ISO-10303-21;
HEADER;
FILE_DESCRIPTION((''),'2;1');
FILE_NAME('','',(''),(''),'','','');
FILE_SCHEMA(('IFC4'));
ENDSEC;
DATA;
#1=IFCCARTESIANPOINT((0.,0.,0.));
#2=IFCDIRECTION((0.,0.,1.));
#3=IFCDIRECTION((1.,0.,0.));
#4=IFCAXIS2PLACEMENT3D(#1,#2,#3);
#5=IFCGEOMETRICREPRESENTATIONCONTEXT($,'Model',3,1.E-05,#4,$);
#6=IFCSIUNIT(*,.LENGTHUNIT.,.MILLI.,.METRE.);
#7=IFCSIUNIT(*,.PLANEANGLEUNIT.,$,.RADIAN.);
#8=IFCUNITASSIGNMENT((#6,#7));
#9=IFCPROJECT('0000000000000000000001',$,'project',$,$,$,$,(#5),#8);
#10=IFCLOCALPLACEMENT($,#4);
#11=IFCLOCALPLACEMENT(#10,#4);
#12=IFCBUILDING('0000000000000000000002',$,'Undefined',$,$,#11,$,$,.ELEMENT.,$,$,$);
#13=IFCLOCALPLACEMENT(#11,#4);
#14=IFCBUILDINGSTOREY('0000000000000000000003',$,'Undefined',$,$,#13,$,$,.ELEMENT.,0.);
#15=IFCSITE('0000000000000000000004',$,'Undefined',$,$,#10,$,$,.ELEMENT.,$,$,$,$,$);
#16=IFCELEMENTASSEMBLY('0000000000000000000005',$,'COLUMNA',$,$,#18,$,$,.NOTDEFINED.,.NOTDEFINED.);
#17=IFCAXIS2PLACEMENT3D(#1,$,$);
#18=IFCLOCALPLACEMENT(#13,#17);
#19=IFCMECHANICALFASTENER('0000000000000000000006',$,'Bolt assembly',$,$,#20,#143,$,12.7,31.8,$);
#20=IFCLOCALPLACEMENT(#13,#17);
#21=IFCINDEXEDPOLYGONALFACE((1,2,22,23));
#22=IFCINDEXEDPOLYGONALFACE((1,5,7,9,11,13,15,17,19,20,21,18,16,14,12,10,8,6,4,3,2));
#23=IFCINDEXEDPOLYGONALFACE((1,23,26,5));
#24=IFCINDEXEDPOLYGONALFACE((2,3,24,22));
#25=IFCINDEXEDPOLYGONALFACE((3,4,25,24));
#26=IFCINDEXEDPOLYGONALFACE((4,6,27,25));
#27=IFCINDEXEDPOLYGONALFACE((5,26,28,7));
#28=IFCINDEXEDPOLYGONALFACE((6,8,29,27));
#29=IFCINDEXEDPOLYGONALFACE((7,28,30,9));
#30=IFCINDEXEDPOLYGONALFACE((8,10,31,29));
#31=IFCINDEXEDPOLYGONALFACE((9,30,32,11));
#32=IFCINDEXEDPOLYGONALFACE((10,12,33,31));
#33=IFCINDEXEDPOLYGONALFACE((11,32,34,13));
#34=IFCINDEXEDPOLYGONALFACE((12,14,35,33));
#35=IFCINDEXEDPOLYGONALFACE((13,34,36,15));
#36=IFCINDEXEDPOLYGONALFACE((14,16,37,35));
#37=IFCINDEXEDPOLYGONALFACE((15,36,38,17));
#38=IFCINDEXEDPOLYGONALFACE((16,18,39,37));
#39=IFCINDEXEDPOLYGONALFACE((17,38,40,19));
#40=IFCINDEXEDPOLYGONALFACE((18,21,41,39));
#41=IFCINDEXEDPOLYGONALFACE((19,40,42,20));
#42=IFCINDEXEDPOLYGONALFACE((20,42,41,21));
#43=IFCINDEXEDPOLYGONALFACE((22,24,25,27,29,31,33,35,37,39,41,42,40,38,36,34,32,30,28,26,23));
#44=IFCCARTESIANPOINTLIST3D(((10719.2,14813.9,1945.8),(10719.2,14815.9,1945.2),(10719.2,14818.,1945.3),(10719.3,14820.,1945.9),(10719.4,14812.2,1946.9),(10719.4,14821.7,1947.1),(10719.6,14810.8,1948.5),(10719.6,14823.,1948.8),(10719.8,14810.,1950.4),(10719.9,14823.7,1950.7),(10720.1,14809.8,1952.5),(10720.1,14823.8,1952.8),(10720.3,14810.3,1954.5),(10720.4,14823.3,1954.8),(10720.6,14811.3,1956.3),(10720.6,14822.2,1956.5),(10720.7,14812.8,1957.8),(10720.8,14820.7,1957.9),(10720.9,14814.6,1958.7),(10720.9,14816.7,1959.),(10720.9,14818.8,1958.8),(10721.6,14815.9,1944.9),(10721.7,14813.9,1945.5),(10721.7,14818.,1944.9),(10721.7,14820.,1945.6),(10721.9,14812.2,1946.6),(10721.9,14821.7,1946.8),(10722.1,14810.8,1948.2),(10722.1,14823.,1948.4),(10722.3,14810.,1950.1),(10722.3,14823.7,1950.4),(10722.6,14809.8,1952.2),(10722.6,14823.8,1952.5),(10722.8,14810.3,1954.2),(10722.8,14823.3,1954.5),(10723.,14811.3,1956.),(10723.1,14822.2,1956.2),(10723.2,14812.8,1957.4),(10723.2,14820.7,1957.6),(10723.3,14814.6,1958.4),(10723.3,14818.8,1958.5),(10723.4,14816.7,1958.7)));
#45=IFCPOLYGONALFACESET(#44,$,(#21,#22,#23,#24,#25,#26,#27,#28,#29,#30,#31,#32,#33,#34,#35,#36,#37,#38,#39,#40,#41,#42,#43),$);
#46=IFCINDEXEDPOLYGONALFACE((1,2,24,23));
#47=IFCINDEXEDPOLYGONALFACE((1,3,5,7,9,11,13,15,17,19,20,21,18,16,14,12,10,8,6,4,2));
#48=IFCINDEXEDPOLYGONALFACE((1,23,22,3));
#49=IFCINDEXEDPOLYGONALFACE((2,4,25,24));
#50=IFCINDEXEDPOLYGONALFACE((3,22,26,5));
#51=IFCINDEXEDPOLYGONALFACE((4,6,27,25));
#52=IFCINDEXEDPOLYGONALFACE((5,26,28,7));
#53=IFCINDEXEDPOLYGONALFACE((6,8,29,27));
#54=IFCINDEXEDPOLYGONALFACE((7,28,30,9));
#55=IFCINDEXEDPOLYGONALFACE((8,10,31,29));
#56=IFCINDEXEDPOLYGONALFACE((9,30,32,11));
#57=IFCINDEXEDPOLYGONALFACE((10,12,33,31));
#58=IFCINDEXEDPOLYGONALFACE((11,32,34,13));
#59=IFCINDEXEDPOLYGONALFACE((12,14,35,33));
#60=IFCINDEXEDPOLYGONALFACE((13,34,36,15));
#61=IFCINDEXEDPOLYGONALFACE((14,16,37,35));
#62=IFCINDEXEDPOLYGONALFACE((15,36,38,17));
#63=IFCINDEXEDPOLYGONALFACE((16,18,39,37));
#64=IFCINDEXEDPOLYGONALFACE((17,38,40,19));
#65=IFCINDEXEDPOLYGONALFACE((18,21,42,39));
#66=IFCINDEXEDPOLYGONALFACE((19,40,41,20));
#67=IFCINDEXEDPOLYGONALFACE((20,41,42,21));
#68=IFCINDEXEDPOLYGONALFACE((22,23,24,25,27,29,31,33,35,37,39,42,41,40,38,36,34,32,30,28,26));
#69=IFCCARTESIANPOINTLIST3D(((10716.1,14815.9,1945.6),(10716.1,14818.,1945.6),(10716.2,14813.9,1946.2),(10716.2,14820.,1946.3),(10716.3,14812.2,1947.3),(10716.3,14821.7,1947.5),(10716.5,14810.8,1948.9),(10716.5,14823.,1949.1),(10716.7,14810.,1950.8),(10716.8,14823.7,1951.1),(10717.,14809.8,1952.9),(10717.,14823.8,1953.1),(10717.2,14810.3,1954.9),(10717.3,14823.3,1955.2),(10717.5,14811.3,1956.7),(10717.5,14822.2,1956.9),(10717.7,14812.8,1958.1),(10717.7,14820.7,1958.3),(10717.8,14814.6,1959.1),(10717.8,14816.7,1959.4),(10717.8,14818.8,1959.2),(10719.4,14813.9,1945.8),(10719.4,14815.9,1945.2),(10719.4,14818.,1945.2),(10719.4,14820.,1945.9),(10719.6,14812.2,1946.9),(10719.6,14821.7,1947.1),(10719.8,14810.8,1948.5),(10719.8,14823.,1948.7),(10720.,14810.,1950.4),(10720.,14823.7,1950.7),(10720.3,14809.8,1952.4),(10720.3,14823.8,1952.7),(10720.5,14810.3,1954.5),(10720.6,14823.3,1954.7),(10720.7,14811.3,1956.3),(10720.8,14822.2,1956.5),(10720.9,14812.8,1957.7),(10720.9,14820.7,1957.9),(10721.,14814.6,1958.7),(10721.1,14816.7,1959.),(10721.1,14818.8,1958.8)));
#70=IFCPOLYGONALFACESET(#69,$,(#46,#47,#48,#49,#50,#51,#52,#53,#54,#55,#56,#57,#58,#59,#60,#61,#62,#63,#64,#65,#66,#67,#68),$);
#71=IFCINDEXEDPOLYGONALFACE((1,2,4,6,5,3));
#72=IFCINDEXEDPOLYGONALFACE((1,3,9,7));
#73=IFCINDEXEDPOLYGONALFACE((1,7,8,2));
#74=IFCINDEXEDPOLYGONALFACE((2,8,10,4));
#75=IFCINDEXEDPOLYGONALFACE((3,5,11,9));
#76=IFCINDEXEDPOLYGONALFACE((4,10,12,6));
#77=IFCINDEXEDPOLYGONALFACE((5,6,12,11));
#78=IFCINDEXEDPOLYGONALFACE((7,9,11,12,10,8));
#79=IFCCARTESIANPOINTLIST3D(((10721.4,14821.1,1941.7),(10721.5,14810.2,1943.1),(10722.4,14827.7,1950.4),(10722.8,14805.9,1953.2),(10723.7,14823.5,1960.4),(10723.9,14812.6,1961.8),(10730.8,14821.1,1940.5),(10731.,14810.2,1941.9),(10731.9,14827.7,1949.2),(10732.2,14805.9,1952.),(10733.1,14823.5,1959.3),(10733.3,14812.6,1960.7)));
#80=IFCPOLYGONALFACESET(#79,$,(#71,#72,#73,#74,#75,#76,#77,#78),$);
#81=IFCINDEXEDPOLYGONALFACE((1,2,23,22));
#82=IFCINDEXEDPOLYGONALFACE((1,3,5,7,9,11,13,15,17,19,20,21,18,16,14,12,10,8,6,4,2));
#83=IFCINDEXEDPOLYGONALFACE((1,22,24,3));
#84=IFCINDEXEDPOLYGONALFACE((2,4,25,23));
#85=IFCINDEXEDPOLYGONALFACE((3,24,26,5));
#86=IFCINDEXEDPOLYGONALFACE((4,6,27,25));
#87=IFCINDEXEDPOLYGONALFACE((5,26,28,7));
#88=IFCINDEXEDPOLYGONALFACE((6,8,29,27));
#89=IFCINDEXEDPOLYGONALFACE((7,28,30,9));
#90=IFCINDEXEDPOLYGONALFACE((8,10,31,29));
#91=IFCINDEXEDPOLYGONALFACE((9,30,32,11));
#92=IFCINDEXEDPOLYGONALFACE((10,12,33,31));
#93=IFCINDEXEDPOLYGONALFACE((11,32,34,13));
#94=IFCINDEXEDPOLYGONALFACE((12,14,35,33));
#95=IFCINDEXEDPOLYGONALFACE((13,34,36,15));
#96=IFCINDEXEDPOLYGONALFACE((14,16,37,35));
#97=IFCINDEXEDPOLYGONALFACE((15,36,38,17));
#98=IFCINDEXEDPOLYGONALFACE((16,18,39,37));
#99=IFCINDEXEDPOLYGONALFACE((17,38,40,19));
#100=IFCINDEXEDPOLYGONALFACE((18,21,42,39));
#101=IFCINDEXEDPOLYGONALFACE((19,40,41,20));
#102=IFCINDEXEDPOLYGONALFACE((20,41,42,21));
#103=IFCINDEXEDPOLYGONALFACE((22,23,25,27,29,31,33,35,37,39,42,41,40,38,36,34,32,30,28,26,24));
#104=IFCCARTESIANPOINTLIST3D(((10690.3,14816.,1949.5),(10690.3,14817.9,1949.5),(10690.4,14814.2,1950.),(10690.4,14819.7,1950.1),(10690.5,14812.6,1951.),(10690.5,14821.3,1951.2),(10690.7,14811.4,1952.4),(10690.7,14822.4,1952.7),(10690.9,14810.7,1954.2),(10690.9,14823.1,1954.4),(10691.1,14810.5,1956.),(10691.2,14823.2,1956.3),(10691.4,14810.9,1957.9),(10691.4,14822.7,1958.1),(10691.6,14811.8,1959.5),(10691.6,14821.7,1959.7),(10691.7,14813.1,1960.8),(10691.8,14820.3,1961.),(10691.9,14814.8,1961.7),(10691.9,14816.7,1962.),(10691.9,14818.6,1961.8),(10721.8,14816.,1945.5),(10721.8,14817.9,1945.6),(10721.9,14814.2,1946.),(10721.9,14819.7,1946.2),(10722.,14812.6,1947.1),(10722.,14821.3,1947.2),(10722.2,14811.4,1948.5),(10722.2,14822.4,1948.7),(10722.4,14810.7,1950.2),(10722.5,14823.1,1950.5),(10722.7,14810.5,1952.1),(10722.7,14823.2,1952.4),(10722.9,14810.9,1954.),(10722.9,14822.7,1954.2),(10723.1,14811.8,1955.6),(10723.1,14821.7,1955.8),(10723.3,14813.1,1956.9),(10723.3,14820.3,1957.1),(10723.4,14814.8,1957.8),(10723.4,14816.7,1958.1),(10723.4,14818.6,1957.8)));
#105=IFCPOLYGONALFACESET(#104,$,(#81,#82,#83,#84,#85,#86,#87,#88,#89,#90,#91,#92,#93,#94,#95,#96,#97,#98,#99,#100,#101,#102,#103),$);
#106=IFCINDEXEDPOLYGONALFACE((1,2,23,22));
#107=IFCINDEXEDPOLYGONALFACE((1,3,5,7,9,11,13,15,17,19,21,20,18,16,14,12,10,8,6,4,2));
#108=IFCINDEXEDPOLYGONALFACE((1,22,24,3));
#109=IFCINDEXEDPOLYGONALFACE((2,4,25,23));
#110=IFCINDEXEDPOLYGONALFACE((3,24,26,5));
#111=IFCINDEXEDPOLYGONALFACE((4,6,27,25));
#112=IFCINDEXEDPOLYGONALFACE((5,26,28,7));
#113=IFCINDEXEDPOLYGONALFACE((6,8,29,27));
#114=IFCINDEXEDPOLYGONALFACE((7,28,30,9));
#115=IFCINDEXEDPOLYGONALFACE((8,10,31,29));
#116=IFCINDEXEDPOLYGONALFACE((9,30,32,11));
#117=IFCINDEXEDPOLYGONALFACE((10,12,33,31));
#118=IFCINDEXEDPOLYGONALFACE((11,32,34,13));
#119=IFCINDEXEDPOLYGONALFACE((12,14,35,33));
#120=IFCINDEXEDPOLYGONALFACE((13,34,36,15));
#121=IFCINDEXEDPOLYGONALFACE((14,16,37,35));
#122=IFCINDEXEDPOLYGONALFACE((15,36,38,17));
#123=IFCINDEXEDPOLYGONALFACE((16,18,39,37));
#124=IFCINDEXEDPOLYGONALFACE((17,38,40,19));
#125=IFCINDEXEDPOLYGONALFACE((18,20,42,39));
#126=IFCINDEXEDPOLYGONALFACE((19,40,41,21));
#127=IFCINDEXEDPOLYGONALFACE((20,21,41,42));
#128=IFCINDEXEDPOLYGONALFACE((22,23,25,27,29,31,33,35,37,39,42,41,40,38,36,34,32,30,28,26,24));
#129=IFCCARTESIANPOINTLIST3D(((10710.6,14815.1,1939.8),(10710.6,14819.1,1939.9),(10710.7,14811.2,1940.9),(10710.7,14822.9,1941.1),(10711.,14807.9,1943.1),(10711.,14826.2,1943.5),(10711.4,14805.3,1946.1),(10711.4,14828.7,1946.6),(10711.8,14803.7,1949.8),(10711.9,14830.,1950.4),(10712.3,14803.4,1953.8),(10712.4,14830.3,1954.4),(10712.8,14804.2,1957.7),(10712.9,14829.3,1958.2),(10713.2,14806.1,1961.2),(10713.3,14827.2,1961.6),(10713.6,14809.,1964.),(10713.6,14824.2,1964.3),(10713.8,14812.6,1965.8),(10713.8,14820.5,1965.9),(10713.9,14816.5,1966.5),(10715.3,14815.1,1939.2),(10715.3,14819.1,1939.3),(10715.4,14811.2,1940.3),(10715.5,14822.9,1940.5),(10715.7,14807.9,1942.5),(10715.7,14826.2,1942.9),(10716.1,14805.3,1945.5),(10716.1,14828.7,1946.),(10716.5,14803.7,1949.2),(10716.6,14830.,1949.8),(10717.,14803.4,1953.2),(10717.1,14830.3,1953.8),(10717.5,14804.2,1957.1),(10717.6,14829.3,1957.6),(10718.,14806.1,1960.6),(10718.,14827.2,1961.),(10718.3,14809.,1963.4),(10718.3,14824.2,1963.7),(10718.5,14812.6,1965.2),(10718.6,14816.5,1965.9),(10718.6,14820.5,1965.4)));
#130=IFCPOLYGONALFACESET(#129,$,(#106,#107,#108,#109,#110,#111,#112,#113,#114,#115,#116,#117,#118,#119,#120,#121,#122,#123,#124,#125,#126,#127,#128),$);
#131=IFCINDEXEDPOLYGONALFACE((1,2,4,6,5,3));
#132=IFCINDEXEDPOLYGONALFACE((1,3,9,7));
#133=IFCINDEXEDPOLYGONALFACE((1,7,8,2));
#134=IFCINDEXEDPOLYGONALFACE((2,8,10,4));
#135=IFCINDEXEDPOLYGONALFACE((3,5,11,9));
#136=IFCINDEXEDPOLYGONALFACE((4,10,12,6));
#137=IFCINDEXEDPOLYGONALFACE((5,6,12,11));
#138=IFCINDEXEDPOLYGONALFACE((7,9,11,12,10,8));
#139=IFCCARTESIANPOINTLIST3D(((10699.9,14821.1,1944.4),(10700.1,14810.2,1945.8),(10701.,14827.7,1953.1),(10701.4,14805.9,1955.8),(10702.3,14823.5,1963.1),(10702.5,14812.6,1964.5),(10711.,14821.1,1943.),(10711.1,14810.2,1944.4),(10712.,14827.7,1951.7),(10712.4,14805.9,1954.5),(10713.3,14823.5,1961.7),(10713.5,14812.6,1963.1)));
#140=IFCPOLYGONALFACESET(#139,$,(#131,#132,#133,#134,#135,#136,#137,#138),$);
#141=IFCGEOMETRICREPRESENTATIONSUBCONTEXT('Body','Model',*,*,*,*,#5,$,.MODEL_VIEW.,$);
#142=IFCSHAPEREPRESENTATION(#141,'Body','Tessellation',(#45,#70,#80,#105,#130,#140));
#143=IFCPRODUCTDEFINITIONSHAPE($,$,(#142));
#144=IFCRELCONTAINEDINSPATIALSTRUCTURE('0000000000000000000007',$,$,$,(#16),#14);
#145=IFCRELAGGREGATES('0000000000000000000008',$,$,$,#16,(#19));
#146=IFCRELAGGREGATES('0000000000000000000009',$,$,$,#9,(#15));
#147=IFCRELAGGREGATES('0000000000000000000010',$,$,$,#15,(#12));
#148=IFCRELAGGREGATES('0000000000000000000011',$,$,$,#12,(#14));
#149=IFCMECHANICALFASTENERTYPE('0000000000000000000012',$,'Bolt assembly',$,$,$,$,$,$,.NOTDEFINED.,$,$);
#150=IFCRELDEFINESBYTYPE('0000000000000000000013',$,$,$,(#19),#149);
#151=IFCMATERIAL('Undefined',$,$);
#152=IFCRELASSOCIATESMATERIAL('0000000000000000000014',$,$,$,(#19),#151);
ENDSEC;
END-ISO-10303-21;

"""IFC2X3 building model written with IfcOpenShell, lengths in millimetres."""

from ifc_helpers import new_model, si_unit, frame, origin_with_axes, origin_2d_with_axis, place, context, subcontext, project, spatial, polyline, circle, outline, extrude, source, transform, mapped, material, type_object, element, aggregate, save


model = new_model("IFC2X3")

# Units and contexts
model_context = context("Model", 3, precision=1e-05, world=origin_with_axes())
body_context = subcontext(model_context, "Body", "Model", "MODEL_VIEW")
ifc_project = project(units=[si_unit("LENGTHUNIT", "METRE", prefix="MILLI"), si_unit("PLANEANGLEUNIT", "RADIAN")], contexts=[model_context])

# Site, building, storey
site_placement = place(None, origin_with_axes())
site = spatial("IfcSite", under=ifc_project, at=site_placement, Name="Undefined", CompositionType="ELEMENT")
building_placement = place(site_placement, origin_with_axes())
building = spatial("IfcBuilding", under=site, at=building_placement, Name="Undefined", CompositionType="ELEMENT")
storey_placement = place(building_placement, origin_with_axes())
storey = spatial("IfcBuildingStorey", under=building, at=storey_placement, Name="Undefined", CompositionType="ELEMENT", Elevation=0.0)

# Element assembly
assembly_1_placement = place(storey_placement, origin_with_axes())
assembly_1 = element("IfcElementAssembly", 1, at=assembly_1_placement, inside=storey, Name="COLUMNA", AssemblyPlace="NOTDEFINED", PredefinedType="NOTDEFINED")

# Shared definitions
ifc_material_1 = material(Name="Undefined")
mechanical_fastener_type = type_object("IfcMechanicalFastenerType", Name="Bolt assembly")

# Mechanical fastener
shared_shape_1 = source(origin_with_axes(), body_context, "Body", "SweptSolid", [
    extrude(circle(Radius=7.0, at=origin_2d_with_axis()), frame((0.0, -2.4, 0.0), z_axis=(0.0, 1.0, 0.0), x_axis=(1.0, 0.0, 0.0)), (0.0, 0.0, 1.0), 2.5),
    extrude(circle(Radius=7.0, at=origin_2d_with_axis()), frame((0.0, -0.1, 0.0), z_axis=(0.0, 1.0, 0.0), x_axis=(1.0, 0.0, 0.0)), (0.0, 0.0, 1.0), 3.3),
    extrude(outline(polyline([(9.5, -5.5), (9.5, 5.5), (0.0, 11.0), (-9.5, 5.5), (-9.5, -5.5), (0.0, -11.0), (9.5, -5.5)])), frame((0.0, -12.0, 0.0), z_axis=(0.0, 1.0, 0.0), x_axis=(1.0, 0.0, 0.0)), (0.0, 0.0, 1.0), 9.5),
    extrude(circle(Radius=6.3, at=origin_2d_with_axis()), frame((0.0, -2.5, 0.0), z_axis=(0.0, 1.0, 0.0), x_axis=(1.0, 0.0, 0.0)), (0.0, 0.0, 1.0), 31.8),
    extrude(circle(Radius=13.5, at=origin_2d_with_axis()), frame((0.0, 3.2, 0.0), z_axis=(0.0, 1.0, 0.0), x_axis=(1.0, 0.0, 0.0)), (0.0, 0.0, 1.0), 4.8),
    extrude(outline(polyline([(9.5, -5.5), (9.5, 5.5), (0.0, 11.0), (-9.5, 5.5), (-9.5, -5.5), (0.0, -11.0), (9.5, -5.5)])), frame((0.0, 8.0, 0.0), z_axis=(0.0, 1.0, 0.0), x_axis=(1.0, 0.0, 0.0)), (0.0, 0.0, 1.0), 11.1),
])
mechanical_fastener_1_placement = place(assembly_1_placement, frame((10720.1, 14816.8, 1952.1), z_axis=(-0.098611, -0.606774, -0.788734), x_axis=(0.075276, -0.794875, 0.602086)))
mechanical_fastener_1 = element("IfcMechanicalFastener", 2, at=mechanical_fastener_1_placement, type_object=mechanical_fastener_type, material=ifc_material_1, Name="Bolt assembly", NominalDiameter=12.7, NominalLength=31.8, context=body_context, shape_type="MappedRepresentation", body=[
    mapped(shared_shape_1, transform((0.0, 0.0, 0.0))),
])
aggregate(assembly_1, [mechanical_fastener_1])

save(model, "model.ifc")
